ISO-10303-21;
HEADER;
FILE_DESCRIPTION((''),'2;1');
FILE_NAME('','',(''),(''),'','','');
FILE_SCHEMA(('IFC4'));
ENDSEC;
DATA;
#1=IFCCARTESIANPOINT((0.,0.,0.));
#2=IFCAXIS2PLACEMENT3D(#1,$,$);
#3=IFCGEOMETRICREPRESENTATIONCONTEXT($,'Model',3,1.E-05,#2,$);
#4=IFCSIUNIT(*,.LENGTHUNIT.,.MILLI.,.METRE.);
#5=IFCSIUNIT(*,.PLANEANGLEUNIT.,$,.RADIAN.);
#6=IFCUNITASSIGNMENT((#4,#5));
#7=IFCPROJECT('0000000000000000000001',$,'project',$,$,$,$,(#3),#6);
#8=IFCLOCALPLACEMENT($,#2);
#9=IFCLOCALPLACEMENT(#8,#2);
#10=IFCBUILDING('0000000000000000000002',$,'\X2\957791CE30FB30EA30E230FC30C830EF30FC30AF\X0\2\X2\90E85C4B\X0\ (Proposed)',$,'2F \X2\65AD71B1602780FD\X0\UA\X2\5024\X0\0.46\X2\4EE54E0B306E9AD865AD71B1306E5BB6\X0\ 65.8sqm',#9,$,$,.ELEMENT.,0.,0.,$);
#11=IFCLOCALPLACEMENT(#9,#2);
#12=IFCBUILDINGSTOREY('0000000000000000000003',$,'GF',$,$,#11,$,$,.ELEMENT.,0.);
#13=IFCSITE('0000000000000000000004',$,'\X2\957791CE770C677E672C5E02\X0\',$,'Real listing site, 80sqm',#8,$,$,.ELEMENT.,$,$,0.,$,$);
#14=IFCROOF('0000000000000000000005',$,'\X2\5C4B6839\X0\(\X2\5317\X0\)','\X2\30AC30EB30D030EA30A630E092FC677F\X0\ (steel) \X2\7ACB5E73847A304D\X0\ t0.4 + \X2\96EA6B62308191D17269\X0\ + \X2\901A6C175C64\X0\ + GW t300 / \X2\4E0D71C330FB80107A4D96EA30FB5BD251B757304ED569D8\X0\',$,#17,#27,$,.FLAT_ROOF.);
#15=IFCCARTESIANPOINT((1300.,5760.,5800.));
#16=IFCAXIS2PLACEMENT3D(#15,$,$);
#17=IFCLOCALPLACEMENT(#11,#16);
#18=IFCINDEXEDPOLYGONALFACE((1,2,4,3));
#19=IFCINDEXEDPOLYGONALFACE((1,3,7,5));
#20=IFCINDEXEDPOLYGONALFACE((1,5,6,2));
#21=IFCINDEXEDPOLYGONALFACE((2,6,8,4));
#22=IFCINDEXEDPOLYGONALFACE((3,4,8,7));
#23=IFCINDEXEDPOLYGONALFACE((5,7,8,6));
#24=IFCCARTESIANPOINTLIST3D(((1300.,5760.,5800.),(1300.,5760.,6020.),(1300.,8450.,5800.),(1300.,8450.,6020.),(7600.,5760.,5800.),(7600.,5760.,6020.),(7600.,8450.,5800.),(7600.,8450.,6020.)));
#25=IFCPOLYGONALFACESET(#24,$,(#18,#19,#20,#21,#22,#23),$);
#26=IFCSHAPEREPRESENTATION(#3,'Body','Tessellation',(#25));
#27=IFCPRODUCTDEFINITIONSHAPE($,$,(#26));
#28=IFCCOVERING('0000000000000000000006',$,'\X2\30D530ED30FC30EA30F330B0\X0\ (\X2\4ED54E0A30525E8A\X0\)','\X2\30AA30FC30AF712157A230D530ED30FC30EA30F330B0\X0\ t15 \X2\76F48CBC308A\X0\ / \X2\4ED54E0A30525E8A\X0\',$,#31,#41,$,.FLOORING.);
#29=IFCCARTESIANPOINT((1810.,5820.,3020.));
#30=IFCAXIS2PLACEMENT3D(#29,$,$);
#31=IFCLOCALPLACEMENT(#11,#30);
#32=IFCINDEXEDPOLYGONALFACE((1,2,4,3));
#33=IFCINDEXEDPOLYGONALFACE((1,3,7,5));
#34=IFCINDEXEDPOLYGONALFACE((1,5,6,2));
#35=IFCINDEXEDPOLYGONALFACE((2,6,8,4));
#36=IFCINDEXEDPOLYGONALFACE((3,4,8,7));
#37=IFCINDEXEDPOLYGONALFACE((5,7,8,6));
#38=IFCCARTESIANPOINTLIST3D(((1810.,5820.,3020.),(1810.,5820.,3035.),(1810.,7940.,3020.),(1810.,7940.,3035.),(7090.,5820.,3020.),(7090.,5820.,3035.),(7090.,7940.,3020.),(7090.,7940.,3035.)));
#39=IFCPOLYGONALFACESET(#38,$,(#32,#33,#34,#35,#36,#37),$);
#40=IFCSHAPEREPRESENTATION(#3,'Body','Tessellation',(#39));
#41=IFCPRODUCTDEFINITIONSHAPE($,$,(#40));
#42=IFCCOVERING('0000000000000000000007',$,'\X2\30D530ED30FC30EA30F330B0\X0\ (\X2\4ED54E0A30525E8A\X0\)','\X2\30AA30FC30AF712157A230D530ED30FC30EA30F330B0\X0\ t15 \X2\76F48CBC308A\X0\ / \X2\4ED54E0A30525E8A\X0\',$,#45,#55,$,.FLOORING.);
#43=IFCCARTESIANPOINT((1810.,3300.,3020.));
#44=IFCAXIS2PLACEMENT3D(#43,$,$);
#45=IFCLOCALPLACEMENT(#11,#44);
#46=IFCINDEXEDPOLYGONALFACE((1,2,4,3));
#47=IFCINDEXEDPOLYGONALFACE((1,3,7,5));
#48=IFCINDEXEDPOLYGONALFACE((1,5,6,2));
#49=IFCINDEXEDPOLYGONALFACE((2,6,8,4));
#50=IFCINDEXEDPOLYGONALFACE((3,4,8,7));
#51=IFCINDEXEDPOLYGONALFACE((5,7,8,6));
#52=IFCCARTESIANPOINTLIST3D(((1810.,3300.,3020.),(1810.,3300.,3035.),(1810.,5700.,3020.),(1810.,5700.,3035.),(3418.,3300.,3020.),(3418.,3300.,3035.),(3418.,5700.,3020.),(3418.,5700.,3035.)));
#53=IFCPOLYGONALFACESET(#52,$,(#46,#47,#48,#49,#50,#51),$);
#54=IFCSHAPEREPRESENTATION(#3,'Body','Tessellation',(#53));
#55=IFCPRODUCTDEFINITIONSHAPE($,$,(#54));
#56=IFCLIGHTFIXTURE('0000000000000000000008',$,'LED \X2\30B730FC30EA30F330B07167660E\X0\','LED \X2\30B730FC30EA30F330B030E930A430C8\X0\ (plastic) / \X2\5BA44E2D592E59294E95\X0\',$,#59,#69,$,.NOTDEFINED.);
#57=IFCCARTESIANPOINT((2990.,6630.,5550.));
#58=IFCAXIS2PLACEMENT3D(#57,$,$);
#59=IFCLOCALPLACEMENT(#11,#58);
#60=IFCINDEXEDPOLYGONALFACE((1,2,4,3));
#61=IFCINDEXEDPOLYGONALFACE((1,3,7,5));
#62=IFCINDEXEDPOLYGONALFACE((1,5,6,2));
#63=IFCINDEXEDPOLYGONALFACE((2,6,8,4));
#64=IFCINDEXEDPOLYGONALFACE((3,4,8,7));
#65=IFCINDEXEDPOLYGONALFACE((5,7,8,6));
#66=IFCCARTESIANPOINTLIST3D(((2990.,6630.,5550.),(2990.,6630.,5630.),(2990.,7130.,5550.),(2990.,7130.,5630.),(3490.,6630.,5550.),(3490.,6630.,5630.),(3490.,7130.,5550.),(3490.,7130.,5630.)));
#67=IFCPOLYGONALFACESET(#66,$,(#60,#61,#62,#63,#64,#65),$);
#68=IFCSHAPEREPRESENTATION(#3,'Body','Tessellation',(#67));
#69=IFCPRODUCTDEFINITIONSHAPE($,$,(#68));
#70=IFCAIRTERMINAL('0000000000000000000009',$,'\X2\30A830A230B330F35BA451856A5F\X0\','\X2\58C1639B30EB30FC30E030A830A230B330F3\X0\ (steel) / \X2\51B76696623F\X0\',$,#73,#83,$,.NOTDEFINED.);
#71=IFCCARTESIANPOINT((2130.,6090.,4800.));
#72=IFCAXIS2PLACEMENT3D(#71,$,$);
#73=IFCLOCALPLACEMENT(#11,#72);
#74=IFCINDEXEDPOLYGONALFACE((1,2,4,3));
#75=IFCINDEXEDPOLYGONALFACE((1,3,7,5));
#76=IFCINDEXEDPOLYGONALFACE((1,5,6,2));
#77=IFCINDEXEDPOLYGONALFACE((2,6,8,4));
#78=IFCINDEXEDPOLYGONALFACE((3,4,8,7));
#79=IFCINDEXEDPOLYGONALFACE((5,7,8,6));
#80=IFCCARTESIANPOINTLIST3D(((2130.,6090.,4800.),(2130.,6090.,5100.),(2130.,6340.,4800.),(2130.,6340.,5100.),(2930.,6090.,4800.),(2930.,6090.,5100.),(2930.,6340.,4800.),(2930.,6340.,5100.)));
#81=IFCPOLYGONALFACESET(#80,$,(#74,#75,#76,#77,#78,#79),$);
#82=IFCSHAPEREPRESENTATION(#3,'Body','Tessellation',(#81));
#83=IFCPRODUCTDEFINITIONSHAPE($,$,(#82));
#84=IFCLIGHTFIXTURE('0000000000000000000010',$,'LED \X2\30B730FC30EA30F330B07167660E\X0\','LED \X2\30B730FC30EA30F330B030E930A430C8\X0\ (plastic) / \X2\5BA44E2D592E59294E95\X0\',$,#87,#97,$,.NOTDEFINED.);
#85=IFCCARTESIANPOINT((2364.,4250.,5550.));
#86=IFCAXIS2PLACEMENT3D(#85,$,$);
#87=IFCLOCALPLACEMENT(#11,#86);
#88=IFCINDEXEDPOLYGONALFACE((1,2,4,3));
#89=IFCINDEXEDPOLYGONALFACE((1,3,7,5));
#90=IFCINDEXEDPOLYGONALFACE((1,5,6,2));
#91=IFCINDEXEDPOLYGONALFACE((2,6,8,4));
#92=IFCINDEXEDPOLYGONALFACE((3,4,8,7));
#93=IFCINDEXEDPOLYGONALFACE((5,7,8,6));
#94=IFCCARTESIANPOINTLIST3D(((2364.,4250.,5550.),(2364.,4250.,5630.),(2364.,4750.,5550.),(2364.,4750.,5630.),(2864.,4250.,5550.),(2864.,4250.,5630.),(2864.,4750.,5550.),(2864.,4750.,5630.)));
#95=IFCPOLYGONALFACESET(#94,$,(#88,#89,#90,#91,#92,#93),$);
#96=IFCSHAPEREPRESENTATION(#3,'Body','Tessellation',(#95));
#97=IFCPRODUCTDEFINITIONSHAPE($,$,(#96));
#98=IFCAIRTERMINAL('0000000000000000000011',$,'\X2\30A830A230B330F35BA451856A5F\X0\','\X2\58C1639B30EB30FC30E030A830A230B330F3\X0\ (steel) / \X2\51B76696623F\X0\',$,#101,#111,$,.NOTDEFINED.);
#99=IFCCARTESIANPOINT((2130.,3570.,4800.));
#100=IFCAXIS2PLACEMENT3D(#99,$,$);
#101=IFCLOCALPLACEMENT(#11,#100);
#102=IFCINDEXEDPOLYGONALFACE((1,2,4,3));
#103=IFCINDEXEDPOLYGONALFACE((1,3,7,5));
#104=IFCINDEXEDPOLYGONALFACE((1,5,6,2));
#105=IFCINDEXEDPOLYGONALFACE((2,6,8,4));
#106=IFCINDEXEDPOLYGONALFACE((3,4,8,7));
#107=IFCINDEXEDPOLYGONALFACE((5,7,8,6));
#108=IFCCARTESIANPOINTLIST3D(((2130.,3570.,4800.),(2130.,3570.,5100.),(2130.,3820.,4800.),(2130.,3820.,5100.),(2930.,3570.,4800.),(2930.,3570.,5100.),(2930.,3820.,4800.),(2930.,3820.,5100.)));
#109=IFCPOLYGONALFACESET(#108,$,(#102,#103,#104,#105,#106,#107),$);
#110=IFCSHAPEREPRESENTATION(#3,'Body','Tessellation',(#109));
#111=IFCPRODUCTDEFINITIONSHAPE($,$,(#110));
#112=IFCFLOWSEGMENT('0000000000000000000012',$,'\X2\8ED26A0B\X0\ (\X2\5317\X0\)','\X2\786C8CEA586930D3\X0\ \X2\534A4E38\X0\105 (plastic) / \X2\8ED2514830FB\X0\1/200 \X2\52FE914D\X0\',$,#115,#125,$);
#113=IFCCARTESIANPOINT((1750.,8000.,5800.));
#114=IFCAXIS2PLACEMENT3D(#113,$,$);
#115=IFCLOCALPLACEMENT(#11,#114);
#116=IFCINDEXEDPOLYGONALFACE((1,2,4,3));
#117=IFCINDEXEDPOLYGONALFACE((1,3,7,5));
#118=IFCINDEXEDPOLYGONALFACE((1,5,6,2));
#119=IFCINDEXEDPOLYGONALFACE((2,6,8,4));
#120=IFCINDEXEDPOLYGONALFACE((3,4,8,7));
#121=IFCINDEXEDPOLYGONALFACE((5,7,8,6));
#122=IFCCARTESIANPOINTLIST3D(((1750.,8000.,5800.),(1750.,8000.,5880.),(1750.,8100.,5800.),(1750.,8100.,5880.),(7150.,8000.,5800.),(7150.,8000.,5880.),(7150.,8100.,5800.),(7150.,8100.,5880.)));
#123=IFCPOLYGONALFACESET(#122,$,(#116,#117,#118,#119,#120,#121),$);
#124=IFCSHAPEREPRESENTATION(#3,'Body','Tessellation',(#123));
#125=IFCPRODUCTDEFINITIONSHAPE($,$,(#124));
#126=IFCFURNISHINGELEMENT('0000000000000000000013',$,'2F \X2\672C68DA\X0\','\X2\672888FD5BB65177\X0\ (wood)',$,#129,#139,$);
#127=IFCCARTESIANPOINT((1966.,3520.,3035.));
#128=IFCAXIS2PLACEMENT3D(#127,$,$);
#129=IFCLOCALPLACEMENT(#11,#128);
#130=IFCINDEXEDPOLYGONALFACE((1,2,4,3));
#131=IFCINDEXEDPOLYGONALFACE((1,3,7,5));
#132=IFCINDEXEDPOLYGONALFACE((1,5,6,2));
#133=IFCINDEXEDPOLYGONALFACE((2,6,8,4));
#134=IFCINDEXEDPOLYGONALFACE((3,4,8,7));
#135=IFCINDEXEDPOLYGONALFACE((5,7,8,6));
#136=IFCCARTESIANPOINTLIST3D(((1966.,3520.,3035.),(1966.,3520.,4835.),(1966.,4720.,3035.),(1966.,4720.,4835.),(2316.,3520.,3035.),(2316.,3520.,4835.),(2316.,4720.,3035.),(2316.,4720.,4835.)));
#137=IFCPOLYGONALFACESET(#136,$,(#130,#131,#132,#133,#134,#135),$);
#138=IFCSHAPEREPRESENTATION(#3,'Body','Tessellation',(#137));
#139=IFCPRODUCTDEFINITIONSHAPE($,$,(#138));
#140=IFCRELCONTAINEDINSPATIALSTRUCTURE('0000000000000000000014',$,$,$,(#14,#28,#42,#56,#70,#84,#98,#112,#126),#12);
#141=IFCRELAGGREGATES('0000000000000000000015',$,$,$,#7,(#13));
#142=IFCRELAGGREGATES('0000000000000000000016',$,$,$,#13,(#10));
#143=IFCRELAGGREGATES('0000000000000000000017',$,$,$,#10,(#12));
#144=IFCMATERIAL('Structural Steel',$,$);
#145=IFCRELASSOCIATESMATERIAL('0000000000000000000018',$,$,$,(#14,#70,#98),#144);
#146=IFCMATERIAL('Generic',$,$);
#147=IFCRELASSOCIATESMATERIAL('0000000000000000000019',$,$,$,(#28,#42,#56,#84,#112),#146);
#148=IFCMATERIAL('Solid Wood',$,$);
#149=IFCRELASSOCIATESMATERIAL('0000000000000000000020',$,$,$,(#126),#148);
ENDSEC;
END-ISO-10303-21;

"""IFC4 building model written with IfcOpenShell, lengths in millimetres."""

from ifc_helpers import new_model, si_unit, frame, frame_2d, origin, place, context, project, spatial, rectangle, extrude, material, element, save


model = new_model("IFC4")

# Units and contexts
model_context = context("Model", 3, precision=1e-05, world=origin())
ifc_project = project(units=[si_unit("LENGTHUNIT", "METRE", prefix="MILLI"), si_unit("PLANEANGLEUNIT", "RADIAN")], contexts=[model_context])

# Site, building, storey
site_placement = place(None, origin())
site = spatial("IfcSite", under=ifc_project, at=site_placement, Name="長野県松本市", ObjectType="Real listing site, 80sqm", CompositionType="ELEMENT", RefElevation=0.0)
building_placement = place(site_placement, origin())
building = spatial("IfcBuilding", under=site, at=building_placement, Name="長野・リモートワーク2部屋 (Proposed)", ObjectType="2F 断熱性能UA値0.46以下の高断熱の家 65.8sqm", CompositionType="ELEMENT", ElevationOfRefHeight=0.0, ElevationOfTerrain=0.0)
storey_placement = place(building_placement, origin())
storey = spatial("IfcBuildingStorey", under=building, at=storey_placement, Name="GF", CompositionType="ELEMENT", Elevation=0.0)

# Shared definitions
ifc_material_1 = material(Name="Solid Wood")

# Roof
ifc_material_2 = material(Name="Structural Steel")
for number, where, name in (
    (1, (1300.0, 5760.0, 5800.0), "屋根(北)"),
):
    element("IfcRoof", number, at=place(storey_placement, frame(where)), inside=storey, material=ifc_material_2, Name=name, Description="ガルバリウム鋼板 (steel) 立平葺き t0.4 + 雪止め金物 + 通気層 + GW t300 / 不燃・耐積雪・寒冷地仕様", PredefinedType="FLAT_ROOF", context=model_context, shape_type="SweptSolid", body=[
        extrude(rectangle(XDim=6300.0, YDim=2690.0, at=frame_2d((3150.0, 1345.0))), frame((1300.0, 5760.0, 5800.0)), (0.0, 0.0, 1.0), 220.0),
    ])

# Coverings
ifc_material_3 = material(Name="Generic")
covering_1_placement = place(storey_placement, frame((1810.0, 5820.0, 3020.0)))
element("IfcCovering", 2, at=covering_1_placement, inside=storey, material=ifc_material_3, Name="フローリング (仕上げ床)", Description="オーク無垢フローリング t15 直貼り / 仕上げ床", PredefinedType="FLOORING", context=model_context, shape_type="SweptSolid", body=[
    extrude(rectangle(XDim=5280.0, YDim=2120.0, at=frame_2d((2640.0, 1060.0))), frame((1810.0, 5820.0, 3020.0)), (0.0, 0.0, 1.0), 15.0),
])
covering_2_placement = place(storey_placement, frame((1810.0, 3300.0, 3020.0)))
element("IfcCovering", 3, at=covering_2_placement, inside=storey, material=ifc_material_3, Name="フローリング (仕上げ床)", Description="オーク無垢フローリング t15 直貼り / 仕上げ床", PredefinedType="FLOORING", context=model_context, shape_type="SweptSolid", body=[
    extrude(rectangle(XDim=1608.0, YDim=2400.0, at=frame_2d((804.0, 1200.0))), frame((1810.0, 3300.0, 3020.0)), (0.0, 0.0, 1.0), 15.0),
])

# Light fixture
light_fixture_1_placement = place(storey_placement, frame((2990.0, 6630.0, 5550.0)))
element("IfcLightFixture", 4, at=light_fixture_1_placement, inside=storey, material=ifc_material_3, Name="LED シーリング照明", Description="LED シーリングライト (plastic) / 室中央天井", PredefinedType="NOTDEFINED", context=model_context, shape_type="SweptSolid", body=[
    extrude(rectangle(XDim=500.0, YDim=500.0, at=frame_2d((250.0, 250.0))), frame((2990.0, 6630.0, 5550.0)), (0.0, 0.0, 1.0), 80.0),
])

# Air terminal
air_terminal_1_placement = place(storey_placement, frame((2130.0, 6090.0, 4800.0)))
element("IfcAirTerminal", 5, at=air_terminal_1_placement, inside=storey, material=ifc_material_2, Name="エアコン室内機", Description="壁掛ルームエアコン (steel) / 冷暖房", PredefinedType="NOTDEFINED", context=model_context, shape_type="SweptSolid", body=[
    extrude(rectangle(XDim=800.0, YDim=250.0, at=frame_2d((400.0, 125.0))), frame((2130.0, 6090.0, 4800.0)), (0.0, 0.0, 1.0), 300.0),
])

# Light fixture
light_fixture_2_placement = place(storey_placement, frame((2364.0, 4250.0, 5550.0)))
element("IfcLightFixture", 6, at=light_fixture_2_placement, inside=storey, material=ifc_material_3, Name="LED シーリング照明", Description="LED シーリングライト (plastic) / 室中央天井", PredefinedType="NOTDEFINED", context=model_context, shape_type="SweptSolid", body=[
    extrude(rectangle(XDim=500.0, YDim=500.0, at=frame_2d((250.0, 250.0))), frame((2364.0, 4250.0, 5550.0)), (0.0, 0.0, 1.0), 80.0),
])

# Air terminal
air_terminal_2_placement = place(storey_placement, frame((2130.0, 3570.0, 4800.0)))
element("IfcAirTerminal", 7, at=air_terminal_2_placement, inside=storey, material=ifc_material_2, Name="エアコン室内機", Description="壁掛ルームエアコン (steel) / 冷暖房", PredefinedType="NOTDEFINED", context=model_context, shape_type="SweptSolid", body=[
    extrude(rectangle(XDim=800.0, YDim=250.0, at=frame_2d((400.0, 125.0))), frame((2130.0, 3570.0, 4800.0)), (0.0, 0.0, 1.0), 300.0),
])

# Flow segment
flow_segment_placement = place(storey_placement, frame((1750.0, 8000.0, 5800.0)))
element("IfcFlowSegment", 8, at=flow_segment_placement, inside=storey, material=ifc_material_3, Name="軒樋 (北)", Description="硬質塩ビ 半丸105 (plastic) / 軒先・1/200 勾配", context=model_context, shape_type="SweptSolid", body=[
    extrude(rectangle(XDim=5400.0, YDim=100.0, at=frame_2d((2700.0, 50.0))), frame((1750.0, 8000.0, 5800.0)), (0.0, 0.0, 1.0), 80.0),
])

# Furnishing element
furnishing_placement = place(storey_placement, frame((1966.0, 3520.0, 3035.0)))
element("IfcFurnishingElement", 9, at=furnishing_placement, inside=storey, material=ifc_material_1, Name="2F 本棚", Description="木製家具 (wood)", context=model_context, shape_type="SweptSolid", body=[
    extrude(rectangle(XDim=350.0, YDim=1200.0, at=frame_2d((175.0, 600.0))), frame((1966.0, 3520.0, 3035.0)), (0.0, 0.0, 1.0), 1800.0),
])

save(model, "model.ifc")
